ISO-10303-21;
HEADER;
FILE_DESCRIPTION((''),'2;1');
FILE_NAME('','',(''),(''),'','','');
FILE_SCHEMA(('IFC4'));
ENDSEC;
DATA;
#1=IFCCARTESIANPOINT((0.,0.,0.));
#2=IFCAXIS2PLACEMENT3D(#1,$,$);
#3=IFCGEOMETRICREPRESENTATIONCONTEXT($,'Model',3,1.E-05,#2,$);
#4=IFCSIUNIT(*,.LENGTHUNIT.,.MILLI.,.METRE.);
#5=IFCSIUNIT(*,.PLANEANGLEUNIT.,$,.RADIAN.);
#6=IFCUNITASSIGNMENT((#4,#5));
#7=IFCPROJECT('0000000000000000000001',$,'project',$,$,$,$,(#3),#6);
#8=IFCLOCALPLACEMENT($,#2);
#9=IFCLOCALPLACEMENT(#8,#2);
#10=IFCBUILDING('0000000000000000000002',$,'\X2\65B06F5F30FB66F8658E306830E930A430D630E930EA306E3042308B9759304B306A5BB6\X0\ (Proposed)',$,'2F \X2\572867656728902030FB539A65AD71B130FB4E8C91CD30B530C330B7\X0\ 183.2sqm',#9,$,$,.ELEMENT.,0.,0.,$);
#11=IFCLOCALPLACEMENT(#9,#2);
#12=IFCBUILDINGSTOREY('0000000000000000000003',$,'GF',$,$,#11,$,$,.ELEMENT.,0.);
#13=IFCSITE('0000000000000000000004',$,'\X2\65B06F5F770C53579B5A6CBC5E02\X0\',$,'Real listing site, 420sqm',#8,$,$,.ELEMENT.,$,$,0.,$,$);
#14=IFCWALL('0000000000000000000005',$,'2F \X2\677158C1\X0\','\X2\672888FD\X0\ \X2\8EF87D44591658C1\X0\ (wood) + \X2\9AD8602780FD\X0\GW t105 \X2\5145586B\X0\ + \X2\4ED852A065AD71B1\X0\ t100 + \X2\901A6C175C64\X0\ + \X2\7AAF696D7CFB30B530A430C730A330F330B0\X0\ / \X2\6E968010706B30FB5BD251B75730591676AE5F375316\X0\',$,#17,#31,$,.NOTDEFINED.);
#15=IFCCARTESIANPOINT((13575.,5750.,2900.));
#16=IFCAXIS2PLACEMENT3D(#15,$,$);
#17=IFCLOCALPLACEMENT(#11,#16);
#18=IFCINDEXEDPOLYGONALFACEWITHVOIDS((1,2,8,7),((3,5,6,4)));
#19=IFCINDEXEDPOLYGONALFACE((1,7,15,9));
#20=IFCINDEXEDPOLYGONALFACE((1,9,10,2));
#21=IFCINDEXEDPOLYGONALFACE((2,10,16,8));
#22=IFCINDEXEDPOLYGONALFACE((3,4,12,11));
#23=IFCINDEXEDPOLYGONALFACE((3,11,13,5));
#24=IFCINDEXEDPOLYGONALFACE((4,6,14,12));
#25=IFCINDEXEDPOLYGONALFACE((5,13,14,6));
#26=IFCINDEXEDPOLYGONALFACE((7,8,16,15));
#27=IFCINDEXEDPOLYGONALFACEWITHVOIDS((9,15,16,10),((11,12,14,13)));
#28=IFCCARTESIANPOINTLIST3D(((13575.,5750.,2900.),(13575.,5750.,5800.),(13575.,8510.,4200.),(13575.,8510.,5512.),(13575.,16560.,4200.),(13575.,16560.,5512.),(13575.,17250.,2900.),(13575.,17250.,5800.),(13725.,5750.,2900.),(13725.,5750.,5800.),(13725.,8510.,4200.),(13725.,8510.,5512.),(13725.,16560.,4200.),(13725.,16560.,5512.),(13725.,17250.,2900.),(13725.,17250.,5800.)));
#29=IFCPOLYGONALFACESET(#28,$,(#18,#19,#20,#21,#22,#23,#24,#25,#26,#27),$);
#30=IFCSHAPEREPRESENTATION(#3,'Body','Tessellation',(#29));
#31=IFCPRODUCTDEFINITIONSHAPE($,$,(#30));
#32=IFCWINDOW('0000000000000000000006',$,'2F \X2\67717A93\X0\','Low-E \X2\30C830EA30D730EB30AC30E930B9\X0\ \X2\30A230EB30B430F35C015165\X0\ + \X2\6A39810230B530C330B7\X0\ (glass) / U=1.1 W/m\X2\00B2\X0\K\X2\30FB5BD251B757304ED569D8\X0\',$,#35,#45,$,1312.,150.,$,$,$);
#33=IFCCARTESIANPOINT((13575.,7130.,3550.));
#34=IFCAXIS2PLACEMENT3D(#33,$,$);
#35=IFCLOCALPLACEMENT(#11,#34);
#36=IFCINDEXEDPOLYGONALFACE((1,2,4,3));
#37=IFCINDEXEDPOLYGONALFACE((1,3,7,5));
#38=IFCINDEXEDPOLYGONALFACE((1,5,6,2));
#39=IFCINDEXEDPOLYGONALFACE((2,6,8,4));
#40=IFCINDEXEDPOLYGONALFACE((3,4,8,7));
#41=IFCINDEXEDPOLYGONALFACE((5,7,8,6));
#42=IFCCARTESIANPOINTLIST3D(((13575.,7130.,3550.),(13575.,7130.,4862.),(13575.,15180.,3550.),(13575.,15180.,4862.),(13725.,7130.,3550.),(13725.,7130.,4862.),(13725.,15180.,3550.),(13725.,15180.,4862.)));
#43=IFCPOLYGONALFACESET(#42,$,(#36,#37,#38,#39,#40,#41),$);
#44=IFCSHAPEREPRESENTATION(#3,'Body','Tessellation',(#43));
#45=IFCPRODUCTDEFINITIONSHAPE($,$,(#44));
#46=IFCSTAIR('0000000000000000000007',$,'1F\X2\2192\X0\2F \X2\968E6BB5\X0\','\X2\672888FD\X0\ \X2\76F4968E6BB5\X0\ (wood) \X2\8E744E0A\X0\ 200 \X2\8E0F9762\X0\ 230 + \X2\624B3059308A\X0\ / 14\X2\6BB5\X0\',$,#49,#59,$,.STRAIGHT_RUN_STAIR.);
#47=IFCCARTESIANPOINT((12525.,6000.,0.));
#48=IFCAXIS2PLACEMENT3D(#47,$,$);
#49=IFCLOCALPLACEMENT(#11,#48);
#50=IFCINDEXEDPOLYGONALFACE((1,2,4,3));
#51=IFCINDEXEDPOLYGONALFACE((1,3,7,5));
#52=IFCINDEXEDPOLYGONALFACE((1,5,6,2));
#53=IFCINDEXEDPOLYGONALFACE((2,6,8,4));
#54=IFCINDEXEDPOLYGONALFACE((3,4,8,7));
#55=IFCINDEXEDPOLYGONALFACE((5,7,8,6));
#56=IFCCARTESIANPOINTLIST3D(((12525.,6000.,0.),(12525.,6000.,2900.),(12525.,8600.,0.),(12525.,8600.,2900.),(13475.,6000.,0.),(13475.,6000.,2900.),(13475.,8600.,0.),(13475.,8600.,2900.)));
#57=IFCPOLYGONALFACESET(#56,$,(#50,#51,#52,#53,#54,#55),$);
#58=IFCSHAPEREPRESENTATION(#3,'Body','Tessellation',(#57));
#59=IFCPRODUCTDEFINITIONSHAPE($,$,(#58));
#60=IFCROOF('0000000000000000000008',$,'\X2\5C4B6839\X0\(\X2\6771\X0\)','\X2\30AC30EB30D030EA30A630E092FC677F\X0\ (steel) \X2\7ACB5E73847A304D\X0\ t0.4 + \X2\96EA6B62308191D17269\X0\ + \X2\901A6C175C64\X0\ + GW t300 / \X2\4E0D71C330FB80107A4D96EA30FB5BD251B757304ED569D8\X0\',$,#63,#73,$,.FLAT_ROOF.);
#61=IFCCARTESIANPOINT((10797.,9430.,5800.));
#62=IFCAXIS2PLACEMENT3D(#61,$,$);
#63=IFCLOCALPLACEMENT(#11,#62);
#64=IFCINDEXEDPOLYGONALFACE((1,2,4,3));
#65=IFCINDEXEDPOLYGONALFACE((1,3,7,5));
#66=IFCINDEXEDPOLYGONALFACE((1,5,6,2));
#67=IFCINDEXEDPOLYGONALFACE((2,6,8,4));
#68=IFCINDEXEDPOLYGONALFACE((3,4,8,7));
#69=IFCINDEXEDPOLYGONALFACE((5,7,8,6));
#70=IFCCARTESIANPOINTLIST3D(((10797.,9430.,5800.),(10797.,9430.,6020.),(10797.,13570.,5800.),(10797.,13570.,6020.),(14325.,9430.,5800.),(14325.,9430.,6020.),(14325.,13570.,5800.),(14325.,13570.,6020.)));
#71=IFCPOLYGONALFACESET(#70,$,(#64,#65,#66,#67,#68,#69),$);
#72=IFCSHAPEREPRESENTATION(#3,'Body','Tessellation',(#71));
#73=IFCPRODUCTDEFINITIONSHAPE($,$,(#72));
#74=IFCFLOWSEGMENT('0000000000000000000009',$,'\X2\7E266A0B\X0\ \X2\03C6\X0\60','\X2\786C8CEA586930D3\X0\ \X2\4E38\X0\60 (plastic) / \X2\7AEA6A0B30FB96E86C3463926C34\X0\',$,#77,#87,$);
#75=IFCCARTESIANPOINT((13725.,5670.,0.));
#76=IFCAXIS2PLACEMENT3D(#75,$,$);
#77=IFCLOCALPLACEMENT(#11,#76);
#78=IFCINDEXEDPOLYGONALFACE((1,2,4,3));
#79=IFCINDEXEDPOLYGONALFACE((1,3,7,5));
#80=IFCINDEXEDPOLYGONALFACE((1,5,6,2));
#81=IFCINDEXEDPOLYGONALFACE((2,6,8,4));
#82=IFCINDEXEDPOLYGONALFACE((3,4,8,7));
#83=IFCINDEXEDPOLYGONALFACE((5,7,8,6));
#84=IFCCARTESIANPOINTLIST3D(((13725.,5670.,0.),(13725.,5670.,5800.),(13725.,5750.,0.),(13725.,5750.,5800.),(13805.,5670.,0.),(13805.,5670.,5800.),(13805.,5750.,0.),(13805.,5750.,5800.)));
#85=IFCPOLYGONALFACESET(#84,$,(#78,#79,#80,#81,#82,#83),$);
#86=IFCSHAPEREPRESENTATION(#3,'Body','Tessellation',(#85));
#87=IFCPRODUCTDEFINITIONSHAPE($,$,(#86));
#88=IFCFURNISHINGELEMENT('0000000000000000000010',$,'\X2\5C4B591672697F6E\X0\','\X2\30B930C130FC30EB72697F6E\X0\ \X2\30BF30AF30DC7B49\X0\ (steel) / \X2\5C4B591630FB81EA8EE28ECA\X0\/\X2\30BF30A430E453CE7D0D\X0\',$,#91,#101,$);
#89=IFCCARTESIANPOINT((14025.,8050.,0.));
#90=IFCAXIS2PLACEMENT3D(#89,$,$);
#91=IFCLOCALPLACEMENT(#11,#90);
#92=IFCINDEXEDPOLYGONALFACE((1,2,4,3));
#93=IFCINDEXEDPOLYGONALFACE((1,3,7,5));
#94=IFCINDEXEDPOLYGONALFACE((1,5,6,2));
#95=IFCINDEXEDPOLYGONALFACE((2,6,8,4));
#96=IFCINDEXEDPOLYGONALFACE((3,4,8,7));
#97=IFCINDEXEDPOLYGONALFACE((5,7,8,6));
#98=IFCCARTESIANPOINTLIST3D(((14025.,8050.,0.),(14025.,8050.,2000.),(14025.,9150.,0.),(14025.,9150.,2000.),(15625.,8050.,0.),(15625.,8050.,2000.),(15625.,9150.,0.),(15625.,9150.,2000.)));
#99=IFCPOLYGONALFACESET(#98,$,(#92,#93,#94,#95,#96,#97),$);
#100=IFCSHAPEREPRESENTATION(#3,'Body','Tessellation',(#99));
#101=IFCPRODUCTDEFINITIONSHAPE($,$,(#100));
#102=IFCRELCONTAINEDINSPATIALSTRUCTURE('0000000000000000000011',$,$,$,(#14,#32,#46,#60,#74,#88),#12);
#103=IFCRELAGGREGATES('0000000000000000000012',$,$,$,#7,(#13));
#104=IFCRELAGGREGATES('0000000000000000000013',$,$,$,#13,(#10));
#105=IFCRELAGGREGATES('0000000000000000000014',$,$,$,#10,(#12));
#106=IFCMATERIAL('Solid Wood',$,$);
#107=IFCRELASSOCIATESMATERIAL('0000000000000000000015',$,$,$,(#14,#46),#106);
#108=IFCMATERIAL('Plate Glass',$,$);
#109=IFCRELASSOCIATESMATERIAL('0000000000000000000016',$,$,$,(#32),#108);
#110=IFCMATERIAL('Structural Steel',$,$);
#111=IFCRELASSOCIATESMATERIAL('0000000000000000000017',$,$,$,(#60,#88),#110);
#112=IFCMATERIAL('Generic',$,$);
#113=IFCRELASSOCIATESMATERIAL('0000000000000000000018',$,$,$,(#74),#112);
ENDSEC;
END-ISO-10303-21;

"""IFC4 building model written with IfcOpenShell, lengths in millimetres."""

from ifc_helpers import new_model, si_unit, frame, frame_2d, origin, place, context, project, spatial, rectangle, extrude, material, element, fill, save


model = new_model("IFC4")

# Units and contexts
model_context = context("Model", 3, precision=1e-05, world=origin())
ifc_project = project(units=[si_unit("LENGTHUNIT", "METRE", prefix="MILLI"), si_unit("PLANEANGLEUNIT", "RADIAN")], contexts=[model_context])

# Site, building, storey
site_placement = place(None, origin())
site = spatial("IfcSite", under=ifc_project, at=site_placement, Name="新潟県南魚沼市", ObjectType="Real listing site, 420sqm", CompositionType="ELEMENT", RefElevation=0.0)
building_placement = place(site_placement, origin())
building = spatial("IfcBuilding", under=site, at=building_placement, Name="新潟・書斎とライブラリのある静かな家 (Proposed)", ObjectType="2F 在来木造・厚断熱・二重サッシ 183.2sqm", CompositionType="ELEMENT", ElevationOfRefHeight=0.0, ElevationOfTerrain=0.0)
storey_placement = place(building_placement, origin())
storey = spatial("IfcBuildingStorey", under=building, at=storey_placement, Name="GF", CompositionType="ELEMENT", Elevation=0.0)

# Shared definitions
ifc_material_1 = material(Name="Solid Wood")

# Wall, opening, window
ifc_material_2 = material(Name="Plate Glass")
wall_1_placement = place(storey_placement, frame((13575.0, 5750.0, 2900.0)))
wall_1 = element("IfcWall", 1, at=wall_1_placement, inside=storey, material=ifc_material_1, Name="2F 東壁", Description="木製 軸組外壁 (wood) + 高性能GW t105 充填 + 付加断熱 t100 + 通気層 + 窯業系サイディング / 準耐火・寒冷地外皮強化", PredefinedType="NOTDEFINED", context=model_context, shape_type="SweptSolid", body=[
    extrude(rectangle(XDim=150.0, YDim=11500.0, at=frame_2d((75.0, 5750.0))), frame((13575.0, 5750.0, 2900.0)), (0.0, 0.0, 1.0), 2900.0),
])
opening_1_placement = place(storey_placement, frame((13575.0, 7130.0, 3550.0)))
opening_1 = element("IfcOpeningElement", 2, at=opening_1_placement, cuts=wall_1, PredefinedType="NOTDEFINED", context=model_context, shape_type="SweptSolid", body=[
    extrude(rectangle(XDim=150.0, YDim=8050.0, at=frame_2d((75.0, 4025.0))), frame((13575.0, 7130.0, 3550.0)), (0.0, 0.0, 1.0), 1312.0),
])
window_1_placement = place(storey_placement, frame((13575.0, 7130.0, 3550.0)))
window_1 = element("IfcWindow", 3, at=window_1_placement, inside=storey, material=ifc_material_2, Name="2F 東窓", Description="Low-E トリプルガラス アルゴン封入 + 樹脂サッシ (glass) / U=1.1 W/m²K・寒冷地仕様", OverallHeight=1312.0, OverallWidth=150.0, context=model_context, shape_type="SweptSolid", body=[
    extrude(rectangle(XDim=150.0, YDim=8050.0, at=frame_2d((75.0, 4025.0))), frame((13575.0, 7130.0, 3550.0)), (0.0, 0.0, 1.0), 1312.0),
])
fill(opening_1, window_1)

# Stair
stair_placement = place(storey_placement, frame((12525.0, 6000.0, 0.0)))
element("IfcStair", 4, at=stair_placement, inside=storey, material=ifc_material_1, Name="1F→2F 階段", Description="木製 直階段 (wood) 蹴上 200 踏面 230 + 手すり / 14段", PredefinedType="STRAIGHT_RUN_STAIR", context=model_context, shape_type="SweptSolid", body=[
    extrude(rectangle(XDim=950.0, YDim=2600.0, at=frame_2d((475.0, 1300.0))), frame((12525.0, 6000.0, 0.0)), (0.0, 0.0, 1.0), 2900.0),
])

# Roof
ifc_material_3 = material(Name="Structural Steel")
roof_placement = place(storey_placement, frame((10797.0, 9430.0, 5800.0)))
element("IfcRoof", 5, at=roof_placement, inside=storey, material=ifc_material_3, Name="屋根(東)", Description="ガルバリウム鋼板 (steel) 立平葺き t0.4 + 雪止め金物 + 通気層 + GW t300 / 不燃・耐積雪・寒冷地仕様", PredefinedType="FLAT_ROOF", context=model_context, shape_type="SweptSolid", body=[
    extrude(rectangle(XDim=3528.0, YDim=4140.0, at=frame_2d((1764.0, 2070.0))), frame((10797.0, 9430.0, 5800.0)), (0.0, 0.0, 1.0), 220.0),
])

# Flow segment
ifc_material_4 = material(Name="Generic")
flow_segment_placement = place(storey_placement, frame((13725.0, 5670.0, 0.0)))
element("IfcFlowSegment", 6, at=flow_segment_placement, inside=storey, material=ifc_material_4, Name="縦樋 φ60", Description="硬質塩ビ 丸60 (plastic) / 竪樋・雨水排水", context=model_context, shape_type="SweptSolid", body=[
    extrude(rectangle(XDim=80.0, YDim=80.0, at=frame_2d((40.0, 40.0))), frame((13725.0, 5670.0, 0.0)), (0.0, 0.0, 1.0), 5800.0),
])

# Furnishing element
furnishing_placement = place(storey_placement, frame((14025.0, 8050.0, 0.0)))
element("IfcFurnishingElement", 7, at=furnishing_placement, inside=storey, material=ifc_material_3, Name="屋外物置", Description="スチール物置 タクボ等 (steel) / 屋外・自転車/タイヤ収納", context=model_context, shape_type="SweptSolid", body=[
    extrude(rectangle(XDim=1600.0, YDim=1100.0, at=frame_2d((800.0, 550.0))), frame((14025.0, 8050.0, 0.0)), (0.0, 0.0, 1.0), 2000.0),
])

save(model, "model.ifc")
